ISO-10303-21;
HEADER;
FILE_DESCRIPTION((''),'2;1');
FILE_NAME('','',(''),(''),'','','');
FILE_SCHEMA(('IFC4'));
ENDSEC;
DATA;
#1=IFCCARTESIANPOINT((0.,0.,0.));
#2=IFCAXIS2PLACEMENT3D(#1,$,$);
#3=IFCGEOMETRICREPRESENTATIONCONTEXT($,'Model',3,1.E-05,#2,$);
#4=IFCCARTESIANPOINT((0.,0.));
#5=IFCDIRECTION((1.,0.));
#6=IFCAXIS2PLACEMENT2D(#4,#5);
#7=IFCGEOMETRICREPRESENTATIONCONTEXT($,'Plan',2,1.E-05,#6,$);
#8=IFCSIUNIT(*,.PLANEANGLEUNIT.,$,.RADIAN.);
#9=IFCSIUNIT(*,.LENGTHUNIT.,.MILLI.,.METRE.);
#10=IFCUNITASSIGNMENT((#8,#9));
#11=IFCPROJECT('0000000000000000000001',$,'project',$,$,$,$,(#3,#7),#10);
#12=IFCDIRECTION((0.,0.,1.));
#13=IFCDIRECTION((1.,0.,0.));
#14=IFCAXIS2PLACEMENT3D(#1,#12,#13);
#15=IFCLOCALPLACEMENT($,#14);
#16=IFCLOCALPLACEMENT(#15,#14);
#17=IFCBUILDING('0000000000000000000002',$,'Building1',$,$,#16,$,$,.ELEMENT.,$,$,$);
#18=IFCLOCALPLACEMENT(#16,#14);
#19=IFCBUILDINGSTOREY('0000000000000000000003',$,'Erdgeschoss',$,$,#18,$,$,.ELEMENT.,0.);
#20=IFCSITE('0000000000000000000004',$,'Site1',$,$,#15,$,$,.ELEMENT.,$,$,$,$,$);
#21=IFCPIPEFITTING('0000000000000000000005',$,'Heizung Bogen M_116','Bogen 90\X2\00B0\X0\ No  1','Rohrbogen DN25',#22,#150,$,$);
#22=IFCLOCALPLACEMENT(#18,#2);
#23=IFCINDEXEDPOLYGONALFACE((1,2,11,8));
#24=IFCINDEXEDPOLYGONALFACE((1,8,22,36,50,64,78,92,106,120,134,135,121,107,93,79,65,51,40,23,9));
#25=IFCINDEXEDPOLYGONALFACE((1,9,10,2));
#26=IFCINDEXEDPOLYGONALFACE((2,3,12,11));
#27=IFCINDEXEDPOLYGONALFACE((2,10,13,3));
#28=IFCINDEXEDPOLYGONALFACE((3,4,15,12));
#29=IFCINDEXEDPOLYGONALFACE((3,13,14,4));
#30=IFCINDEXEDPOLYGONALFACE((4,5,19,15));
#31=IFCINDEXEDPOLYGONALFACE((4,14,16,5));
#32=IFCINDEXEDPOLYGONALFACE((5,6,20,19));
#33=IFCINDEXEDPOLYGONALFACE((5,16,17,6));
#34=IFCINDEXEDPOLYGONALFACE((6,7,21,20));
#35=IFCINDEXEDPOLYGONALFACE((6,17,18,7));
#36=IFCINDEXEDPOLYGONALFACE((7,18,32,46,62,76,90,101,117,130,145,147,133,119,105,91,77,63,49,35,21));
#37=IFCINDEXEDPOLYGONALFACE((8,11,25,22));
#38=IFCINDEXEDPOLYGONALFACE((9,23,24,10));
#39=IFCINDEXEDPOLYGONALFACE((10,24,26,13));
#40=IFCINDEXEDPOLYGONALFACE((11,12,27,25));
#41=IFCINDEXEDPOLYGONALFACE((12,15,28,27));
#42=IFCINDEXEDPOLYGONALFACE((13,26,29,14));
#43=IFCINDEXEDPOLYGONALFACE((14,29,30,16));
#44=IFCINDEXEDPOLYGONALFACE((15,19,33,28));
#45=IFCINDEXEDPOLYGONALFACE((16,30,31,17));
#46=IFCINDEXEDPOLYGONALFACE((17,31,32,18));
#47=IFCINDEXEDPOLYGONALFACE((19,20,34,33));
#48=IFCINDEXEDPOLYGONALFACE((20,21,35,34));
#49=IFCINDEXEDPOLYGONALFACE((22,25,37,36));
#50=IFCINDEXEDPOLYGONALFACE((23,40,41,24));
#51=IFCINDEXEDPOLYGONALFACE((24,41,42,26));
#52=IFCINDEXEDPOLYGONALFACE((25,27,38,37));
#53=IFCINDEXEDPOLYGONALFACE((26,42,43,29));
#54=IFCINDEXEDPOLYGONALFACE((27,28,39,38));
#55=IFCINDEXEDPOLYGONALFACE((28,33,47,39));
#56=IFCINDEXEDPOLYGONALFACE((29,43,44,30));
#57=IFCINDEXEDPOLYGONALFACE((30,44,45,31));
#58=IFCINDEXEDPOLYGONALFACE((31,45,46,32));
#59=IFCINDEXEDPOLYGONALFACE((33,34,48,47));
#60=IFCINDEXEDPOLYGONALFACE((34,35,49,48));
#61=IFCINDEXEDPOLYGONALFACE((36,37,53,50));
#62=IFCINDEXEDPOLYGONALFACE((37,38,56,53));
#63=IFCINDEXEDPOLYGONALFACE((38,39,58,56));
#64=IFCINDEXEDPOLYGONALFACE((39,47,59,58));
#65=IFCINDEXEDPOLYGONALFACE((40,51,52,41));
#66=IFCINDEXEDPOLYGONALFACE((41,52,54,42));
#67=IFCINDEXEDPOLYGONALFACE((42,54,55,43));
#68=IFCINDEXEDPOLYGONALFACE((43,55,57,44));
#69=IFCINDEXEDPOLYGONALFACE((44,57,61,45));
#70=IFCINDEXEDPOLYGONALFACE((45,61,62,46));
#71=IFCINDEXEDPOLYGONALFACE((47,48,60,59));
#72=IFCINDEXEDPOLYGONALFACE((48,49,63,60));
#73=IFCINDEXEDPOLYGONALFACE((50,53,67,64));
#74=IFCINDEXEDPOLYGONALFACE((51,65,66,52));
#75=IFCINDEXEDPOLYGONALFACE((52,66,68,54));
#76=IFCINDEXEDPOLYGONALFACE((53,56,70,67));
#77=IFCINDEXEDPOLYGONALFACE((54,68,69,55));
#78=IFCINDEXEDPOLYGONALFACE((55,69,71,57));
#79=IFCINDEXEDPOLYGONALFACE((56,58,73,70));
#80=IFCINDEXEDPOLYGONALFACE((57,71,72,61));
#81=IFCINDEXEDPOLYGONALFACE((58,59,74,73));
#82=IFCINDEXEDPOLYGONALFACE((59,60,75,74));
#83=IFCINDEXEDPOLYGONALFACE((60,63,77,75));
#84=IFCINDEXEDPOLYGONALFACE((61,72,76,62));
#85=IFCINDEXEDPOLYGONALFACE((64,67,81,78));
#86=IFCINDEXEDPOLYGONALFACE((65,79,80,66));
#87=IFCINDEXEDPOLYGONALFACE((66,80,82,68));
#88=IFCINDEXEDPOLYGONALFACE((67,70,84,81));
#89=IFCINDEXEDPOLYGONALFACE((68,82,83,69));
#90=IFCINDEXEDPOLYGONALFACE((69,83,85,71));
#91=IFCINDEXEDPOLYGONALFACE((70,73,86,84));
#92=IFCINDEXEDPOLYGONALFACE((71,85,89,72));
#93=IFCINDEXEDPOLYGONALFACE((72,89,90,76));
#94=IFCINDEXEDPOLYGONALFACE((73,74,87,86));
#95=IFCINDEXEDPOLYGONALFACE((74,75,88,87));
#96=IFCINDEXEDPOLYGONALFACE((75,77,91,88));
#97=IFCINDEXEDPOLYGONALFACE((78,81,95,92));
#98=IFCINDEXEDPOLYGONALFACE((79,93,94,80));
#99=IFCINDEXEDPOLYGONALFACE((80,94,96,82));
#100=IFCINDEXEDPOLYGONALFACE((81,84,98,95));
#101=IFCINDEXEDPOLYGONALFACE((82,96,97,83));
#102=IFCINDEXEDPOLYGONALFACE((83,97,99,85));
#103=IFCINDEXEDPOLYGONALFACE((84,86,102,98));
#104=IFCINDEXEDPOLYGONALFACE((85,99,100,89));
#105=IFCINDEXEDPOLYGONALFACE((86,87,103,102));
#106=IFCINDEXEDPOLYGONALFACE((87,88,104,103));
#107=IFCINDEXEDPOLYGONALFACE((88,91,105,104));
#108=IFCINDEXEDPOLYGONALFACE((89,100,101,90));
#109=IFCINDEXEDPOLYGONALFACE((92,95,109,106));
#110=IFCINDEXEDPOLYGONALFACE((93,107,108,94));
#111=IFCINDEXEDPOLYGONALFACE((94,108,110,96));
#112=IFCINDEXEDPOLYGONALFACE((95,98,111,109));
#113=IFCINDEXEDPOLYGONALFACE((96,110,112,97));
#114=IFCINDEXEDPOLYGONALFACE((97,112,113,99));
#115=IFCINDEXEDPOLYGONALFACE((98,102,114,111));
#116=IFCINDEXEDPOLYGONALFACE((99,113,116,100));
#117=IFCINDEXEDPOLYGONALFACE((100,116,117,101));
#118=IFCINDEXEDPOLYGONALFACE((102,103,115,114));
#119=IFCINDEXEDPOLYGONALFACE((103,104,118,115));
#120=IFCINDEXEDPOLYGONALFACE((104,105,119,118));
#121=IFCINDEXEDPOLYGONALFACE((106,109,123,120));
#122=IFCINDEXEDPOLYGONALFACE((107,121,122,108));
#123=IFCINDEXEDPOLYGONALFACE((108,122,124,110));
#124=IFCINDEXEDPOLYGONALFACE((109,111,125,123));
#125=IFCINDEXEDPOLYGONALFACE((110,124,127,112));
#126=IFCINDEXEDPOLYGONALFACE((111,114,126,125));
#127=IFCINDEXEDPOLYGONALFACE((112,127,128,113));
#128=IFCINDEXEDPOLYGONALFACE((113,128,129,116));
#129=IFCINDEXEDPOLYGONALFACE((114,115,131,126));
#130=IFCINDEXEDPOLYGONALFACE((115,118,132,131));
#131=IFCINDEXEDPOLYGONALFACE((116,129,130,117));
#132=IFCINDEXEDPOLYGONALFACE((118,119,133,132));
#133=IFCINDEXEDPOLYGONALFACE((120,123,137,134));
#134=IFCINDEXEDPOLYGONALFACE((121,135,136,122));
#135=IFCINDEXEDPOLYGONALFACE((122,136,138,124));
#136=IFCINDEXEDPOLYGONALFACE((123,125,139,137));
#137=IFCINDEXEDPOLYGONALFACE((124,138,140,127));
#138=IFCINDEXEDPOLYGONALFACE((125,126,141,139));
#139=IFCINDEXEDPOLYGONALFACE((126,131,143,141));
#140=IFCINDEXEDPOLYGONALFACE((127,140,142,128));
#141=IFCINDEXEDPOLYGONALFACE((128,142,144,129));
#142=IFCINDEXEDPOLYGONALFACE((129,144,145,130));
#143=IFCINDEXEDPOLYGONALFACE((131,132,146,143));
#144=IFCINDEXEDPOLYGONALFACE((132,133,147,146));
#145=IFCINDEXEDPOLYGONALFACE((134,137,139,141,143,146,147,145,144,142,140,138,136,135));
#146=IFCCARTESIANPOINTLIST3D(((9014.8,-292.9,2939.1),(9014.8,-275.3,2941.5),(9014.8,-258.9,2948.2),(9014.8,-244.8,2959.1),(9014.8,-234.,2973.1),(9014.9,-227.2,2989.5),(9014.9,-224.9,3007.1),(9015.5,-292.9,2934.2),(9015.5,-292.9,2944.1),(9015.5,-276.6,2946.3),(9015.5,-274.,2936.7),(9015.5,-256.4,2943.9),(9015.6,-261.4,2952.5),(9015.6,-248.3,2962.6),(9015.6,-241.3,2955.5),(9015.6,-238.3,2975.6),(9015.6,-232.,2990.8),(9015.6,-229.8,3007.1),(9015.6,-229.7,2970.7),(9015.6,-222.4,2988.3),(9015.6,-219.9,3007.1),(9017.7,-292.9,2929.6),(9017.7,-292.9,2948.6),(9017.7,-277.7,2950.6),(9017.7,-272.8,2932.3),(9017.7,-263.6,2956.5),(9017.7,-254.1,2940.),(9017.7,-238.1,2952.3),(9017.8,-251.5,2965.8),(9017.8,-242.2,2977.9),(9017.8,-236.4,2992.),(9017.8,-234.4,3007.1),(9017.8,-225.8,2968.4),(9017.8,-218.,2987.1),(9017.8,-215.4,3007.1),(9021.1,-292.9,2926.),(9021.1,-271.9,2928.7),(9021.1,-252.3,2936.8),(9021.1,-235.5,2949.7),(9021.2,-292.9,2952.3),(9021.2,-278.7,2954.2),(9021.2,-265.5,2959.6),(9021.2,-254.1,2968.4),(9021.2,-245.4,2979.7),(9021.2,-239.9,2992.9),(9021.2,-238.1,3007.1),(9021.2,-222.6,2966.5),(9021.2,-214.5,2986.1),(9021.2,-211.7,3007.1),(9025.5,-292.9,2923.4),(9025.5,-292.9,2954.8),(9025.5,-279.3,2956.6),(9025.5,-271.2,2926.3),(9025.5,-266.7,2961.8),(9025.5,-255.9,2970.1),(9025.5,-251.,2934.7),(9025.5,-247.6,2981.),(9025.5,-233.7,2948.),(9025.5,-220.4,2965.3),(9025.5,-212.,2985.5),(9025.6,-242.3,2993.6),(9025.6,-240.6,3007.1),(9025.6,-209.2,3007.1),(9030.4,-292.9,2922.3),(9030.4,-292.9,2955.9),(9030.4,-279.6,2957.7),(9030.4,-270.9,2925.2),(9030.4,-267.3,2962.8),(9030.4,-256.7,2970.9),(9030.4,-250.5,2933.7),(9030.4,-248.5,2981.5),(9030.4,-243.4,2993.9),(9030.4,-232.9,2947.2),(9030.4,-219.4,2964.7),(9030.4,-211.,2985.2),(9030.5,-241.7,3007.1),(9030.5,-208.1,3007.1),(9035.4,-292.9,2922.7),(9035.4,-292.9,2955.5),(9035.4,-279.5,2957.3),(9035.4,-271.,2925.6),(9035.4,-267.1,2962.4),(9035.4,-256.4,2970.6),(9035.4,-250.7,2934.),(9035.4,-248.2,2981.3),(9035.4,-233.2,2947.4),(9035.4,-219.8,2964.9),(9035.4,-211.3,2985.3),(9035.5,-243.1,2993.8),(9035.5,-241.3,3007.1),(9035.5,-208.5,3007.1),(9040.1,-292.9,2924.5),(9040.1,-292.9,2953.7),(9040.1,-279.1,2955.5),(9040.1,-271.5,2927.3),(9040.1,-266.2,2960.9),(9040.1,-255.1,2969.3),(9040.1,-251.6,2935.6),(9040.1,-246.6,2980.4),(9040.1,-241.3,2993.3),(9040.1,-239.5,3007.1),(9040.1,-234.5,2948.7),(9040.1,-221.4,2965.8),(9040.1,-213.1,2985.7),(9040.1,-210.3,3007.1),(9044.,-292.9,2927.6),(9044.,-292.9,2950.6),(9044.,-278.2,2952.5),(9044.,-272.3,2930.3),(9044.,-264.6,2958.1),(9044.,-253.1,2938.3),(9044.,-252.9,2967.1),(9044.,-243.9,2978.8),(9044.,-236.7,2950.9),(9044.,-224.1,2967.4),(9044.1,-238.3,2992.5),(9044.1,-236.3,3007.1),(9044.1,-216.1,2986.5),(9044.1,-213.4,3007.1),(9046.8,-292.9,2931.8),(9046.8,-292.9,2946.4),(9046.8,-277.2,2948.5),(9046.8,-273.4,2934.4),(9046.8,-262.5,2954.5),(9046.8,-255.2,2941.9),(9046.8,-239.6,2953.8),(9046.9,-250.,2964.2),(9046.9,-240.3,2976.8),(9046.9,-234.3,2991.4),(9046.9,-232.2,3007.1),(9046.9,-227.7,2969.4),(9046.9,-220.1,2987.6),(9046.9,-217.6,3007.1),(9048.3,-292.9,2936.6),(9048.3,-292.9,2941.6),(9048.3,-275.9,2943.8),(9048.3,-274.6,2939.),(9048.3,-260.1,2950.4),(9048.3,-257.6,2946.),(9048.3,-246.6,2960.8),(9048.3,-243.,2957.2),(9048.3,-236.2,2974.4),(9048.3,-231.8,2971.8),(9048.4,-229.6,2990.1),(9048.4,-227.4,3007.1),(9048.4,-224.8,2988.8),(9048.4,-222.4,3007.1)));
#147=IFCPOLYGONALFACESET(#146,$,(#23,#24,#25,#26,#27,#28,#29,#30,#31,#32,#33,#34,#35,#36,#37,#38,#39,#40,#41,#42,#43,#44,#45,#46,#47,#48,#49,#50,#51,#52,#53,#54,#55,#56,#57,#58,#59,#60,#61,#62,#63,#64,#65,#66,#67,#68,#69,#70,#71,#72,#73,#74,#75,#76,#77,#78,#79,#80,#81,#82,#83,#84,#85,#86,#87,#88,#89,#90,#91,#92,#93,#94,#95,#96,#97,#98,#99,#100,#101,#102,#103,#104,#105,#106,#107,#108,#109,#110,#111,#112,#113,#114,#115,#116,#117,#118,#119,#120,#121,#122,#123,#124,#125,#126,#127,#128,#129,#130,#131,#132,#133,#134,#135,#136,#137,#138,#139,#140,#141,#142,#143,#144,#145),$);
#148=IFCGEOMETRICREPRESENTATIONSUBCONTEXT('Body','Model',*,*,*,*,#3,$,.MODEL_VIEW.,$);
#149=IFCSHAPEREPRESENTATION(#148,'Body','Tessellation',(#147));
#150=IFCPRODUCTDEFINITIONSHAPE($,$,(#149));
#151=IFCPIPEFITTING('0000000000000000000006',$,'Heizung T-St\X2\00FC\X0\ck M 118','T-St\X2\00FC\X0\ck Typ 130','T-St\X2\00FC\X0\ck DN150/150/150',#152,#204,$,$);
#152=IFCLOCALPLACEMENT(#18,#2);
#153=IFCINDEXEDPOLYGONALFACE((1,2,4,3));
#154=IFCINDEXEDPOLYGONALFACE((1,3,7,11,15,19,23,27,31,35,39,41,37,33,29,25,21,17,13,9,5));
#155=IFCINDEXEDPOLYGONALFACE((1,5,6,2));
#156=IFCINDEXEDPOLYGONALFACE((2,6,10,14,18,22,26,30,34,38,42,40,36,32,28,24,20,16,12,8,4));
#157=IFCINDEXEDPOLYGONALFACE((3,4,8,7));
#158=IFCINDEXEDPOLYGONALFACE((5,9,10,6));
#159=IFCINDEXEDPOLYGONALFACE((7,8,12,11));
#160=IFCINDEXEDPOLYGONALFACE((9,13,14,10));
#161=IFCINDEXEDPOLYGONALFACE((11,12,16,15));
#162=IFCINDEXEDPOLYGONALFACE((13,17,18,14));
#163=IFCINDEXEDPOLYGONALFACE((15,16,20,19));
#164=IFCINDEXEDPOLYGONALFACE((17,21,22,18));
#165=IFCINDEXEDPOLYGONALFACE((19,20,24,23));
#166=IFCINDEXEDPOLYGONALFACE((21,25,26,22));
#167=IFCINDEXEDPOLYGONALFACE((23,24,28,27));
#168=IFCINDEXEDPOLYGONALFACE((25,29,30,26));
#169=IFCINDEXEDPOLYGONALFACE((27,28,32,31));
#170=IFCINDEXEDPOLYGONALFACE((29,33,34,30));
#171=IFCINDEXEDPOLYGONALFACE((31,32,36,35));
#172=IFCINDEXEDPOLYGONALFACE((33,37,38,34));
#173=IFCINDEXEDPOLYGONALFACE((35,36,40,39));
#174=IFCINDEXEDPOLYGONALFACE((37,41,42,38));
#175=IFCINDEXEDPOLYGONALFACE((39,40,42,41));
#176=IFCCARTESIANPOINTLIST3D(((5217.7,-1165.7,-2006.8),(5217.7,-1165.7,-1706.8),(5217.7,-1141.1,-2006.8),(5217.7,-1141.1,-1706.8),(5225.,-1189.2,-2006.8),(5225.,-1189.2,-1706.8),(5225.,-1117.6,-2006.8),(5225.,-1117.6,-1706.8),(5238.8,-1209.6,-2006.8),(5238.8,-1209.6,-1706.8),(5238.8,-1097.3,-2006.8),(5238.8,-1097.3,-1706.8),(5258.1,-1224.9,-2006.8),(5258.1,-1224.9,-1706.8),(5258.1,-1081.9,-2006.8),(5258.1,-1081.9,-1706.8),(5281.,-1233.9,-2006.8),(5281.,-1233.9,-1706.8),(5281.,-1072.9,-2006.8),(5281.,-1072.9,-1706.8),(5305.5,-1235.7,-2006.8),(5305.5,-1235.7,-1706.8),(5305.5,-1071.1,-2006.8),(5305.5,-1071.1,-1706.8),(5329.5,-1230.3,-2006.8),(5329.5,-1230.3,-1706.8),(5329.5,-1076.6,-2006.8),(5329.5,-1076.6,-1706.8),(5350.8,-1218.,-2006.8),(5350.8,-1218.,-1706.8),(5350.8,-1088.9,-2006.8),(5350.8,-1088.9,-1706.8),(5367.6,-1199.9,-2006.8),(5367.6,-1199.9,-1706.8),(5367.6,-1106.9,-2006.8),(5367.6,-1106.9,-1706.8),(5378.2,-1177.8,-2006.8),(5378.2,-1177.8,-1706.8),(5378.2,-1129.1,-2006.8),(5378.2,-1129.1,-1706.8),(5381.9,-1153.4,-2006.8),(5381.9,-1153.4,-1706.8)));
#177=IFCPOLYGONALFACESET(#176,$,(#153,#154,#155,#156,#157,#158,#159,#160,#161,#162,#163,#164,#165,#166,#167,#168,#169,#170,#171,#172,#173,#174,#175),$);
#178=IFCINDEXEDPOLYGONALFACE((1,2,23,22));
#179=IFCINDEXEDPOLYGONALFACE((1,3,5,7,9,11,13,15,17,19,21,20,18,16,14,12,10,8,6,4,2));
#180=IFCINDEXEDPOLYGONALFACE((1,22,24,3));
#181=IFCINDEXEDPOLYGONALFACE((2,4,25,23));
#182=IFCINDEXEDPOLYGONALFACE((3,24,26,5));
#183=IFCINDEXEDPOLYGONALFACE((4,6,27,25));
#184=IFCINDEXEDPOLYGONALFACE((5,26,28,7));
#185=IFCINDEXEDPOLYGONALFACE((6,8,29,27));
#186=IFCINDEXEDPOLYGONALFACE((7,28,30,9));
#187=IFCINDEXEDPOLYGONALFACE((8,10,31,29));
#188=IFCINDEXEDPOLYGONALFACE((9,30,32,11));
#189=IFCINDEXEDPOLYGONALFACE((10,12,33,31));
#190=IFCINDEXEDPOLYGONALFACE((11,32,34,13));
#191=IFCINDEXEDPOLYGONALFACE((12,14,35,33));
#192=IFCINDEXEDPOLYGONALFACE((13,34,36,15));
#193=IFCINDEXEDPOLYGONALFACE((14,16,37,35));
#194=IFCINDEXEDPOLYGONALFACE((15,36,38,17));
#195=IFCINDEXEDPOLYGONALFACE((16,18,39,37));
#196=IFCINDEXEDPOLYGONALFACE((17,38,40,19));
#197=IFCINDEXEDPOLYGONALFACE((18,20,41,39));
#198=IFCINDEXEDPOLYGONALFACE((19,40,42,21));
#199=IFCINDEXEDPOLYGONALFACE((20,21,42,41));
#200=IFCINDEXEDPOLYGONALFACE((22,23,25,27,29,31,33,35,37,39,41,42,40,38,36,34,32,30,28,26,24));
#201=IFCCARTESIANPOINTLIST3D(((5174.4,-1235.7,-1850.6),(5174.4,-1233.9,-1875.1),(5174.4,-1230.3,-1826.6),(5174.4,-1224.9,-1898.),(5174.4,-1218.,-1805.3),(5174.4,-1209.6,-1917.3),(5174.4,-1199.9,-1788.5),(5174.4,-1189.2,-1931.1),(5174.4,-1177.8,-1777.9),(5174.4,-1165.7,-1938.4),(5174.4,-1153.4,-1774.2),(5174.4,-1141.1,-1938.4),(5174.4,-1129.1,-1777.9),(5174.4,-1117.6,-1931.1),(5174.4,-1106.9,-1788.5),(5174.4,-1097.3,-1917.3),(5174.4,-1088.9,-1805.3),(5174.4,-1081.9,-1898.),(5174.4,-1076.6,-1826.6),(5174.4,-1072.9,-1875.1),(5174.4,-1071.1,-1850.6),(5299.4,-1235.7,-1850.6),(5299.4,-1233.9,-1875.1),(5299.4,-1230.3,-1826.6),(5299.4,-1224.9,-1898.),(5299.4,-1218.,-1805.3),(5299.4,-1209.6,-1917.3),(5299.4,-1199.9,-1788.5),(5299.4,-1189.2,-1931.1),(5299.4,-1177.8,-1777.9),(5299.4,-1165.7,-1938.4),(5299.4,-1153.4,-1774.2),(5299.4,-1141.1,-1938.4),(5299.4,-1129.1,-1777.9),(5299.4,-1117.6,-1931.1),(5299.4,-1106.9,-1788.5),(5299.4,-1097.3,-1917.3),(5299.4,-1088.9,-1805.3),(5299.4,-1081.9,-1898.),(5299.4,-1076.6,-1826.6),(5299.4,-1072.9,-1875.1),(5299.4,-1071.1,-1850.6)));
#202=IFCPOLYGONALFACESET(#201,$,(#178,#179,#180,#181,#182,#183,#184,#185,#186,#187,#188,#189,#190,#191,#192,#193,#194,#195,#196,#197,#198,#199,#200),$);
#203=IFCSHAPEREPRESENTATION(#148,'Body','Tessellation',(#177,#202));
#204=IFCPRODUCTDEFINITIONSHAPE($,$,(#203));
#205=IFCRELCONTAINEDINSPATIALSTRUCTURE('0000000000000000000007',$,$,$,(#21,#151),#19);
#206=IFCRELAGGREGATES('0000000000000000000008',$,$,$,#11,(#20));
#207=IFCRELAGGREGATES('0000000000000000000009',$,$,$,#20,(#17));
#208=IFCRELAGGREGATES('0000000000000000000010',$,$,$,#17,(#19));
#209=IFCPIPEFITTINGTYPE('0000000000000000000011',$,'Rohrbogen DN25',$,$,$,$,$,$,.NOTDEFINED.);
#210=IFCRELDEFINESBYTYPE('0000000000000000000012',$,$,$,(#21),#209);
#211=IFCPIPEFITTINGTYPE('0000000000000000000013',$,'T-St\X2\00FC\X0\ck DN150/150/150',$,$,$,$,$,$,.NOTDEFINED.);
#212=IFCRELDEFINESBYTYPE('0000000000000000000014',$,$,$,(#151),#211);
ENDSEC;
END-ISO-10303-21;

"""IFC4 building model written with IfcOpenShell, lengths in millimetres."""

from ifc_helpers import new_model, entity, si_unit, frame, origin, origin_with_axes, origin_2d_with_axis, place, context, subcontext, project, spatial, circle, extrude, source, transform, mapped, type_object, element, save


model = new_model("IFC4")

# Units and contexts
model_context = context("Model", 3, precision=1e-05, world=origin())
plan_context = context("Plan", 2, precision=1e-05, world=origin_2d_with_axis())
body_context = subcontext(model_context, "Body", "Model", "MODEL_VIEW")
ifc_project = project(units=[si_unit("PLANEANGLEUNIT", "RADIAN"), si_unit("LENGTHUNIT", "METRE", prefix="MILLI")], contexts=[model_context, plan_context])

# Site, building, storey
site_placement = place(None, origin_with_axes())
site = spatial("IfcSite", under=ifc_project, at=site_placement, Name="Site1", CompositionType="ELEMENT")
building_placement = place(site_placement, origin_with_axes())
building = spatial("IfcBuilding", under=site, at=building_placement, Name="Building1", CompositionType="ELEMENT")
storey_placement = place(building_placement, origin_with_axes())
storey = spatial("IfcBuildingStorey", under=building, at=storey_placement, Name="Erdgeschoss", CompositionType="ELEMENT", Elevation=0.0)

# Pipe fittings
pipe_fitting_type_1 = type_object("IfcPipeFittingType", Name="Rohrbogen DN25", PredefinedType="NOTDEFINED")
shared_shape_1 = source(origin_with_axes(), body_context, "Body", "SolidModel", [
    entity("IfcRevolvedAreaSolid", entity("IfcCircleProfileDef", "AREA", None, entity("IfcAxis2Placement2D", entity("IfcCartesianPoint", [0.0, 0.0]), entity("IfcDirection", [1.0, 0.0])), 16.9), entity("IfcAxis2Placement3D", entity("IfcCartesianPoint", [-42.4, 0.0, -25.6]), entity("IfcDirection", [1.0, 0.0, 0.0]), entity("IfcDirection", [0.0, 0.999999, 0.001207])), entity("IfcAxis1Placement", entity("IfcCartesianPoint", [0.0, 68.0, 0.0]), entity("IfcDirection", [-1.0, 0.0, 0.0])), 1.570796),
])
pipe_fitting_1_placement = place(storey_placement, frame((9031.7, -250.5, 2964.7), z_axis=(0.0, 0.0, 1.0), x_axis=(1.0, 0.0, 0.0)))
element("IfcPipeFitting", 1, at=pipe_fitting_1_placement, inside=storey, type_object=pipe_fitting_type_1, Name="Heizung Bogen M_116", Description="Bogen 90° No  1", ObjectType="Rohrbogen DN25", context=body_context, shape_type="MappedRepresentation", body=[
    mapped(shared_shape_1, transform((0.0, 0.0, 0.0), x_axis=(0.0, 1.0, 0.0), y_axis=(-1.0, 0.0, 0.0), z_axis=(0.0, 0.0, 1.0), scale=1.0)),
])
pipe_fitting_type_2 = type_object("IfcPipeFittingType", Name="T-Stück DN150/150/150", PredefinedType="NOTDEFINED")
pipe_fitting_2_placement = place(storey_placement, frame((5277.8, -1153.4, -1856.8), z_axis=(0.0, 0.0, 1.0), x_axis=(1.0, 0.0, 0.0)))
element("IfcPipeFitting", 2, at=pipe_fitting_2_placement, inside=storey, type_object=pipe_fitting_type_2, Name="Heizung T-Stück M 118", Description="T-Stück Typ 130", ObjectType="T-Stück DN150/150/150", context=body_context, shape_type="SolidModel", body=[
    extrude(circle(Radius=82.5, at=origin_2d_with_axis()), frame((21.6, 0.0, 150.0), z_axis=(0.0, 0.0, -1.0), x_axis=(1.0, 0.0, 0.0)), (0.0, 0.0, 1.0), 300.0),
    extrude(circle(Radius=82.5, at=origin_2d_with_axis()), frame((21.6, 0.0, 0.0), z_axis=(-1.0, 0.0, 0.0), x_axis=(0.0, 0.0, 1.0)), (0.0, 0.0, 1.0), 125.0),
])

save(model, "model.ifc")
